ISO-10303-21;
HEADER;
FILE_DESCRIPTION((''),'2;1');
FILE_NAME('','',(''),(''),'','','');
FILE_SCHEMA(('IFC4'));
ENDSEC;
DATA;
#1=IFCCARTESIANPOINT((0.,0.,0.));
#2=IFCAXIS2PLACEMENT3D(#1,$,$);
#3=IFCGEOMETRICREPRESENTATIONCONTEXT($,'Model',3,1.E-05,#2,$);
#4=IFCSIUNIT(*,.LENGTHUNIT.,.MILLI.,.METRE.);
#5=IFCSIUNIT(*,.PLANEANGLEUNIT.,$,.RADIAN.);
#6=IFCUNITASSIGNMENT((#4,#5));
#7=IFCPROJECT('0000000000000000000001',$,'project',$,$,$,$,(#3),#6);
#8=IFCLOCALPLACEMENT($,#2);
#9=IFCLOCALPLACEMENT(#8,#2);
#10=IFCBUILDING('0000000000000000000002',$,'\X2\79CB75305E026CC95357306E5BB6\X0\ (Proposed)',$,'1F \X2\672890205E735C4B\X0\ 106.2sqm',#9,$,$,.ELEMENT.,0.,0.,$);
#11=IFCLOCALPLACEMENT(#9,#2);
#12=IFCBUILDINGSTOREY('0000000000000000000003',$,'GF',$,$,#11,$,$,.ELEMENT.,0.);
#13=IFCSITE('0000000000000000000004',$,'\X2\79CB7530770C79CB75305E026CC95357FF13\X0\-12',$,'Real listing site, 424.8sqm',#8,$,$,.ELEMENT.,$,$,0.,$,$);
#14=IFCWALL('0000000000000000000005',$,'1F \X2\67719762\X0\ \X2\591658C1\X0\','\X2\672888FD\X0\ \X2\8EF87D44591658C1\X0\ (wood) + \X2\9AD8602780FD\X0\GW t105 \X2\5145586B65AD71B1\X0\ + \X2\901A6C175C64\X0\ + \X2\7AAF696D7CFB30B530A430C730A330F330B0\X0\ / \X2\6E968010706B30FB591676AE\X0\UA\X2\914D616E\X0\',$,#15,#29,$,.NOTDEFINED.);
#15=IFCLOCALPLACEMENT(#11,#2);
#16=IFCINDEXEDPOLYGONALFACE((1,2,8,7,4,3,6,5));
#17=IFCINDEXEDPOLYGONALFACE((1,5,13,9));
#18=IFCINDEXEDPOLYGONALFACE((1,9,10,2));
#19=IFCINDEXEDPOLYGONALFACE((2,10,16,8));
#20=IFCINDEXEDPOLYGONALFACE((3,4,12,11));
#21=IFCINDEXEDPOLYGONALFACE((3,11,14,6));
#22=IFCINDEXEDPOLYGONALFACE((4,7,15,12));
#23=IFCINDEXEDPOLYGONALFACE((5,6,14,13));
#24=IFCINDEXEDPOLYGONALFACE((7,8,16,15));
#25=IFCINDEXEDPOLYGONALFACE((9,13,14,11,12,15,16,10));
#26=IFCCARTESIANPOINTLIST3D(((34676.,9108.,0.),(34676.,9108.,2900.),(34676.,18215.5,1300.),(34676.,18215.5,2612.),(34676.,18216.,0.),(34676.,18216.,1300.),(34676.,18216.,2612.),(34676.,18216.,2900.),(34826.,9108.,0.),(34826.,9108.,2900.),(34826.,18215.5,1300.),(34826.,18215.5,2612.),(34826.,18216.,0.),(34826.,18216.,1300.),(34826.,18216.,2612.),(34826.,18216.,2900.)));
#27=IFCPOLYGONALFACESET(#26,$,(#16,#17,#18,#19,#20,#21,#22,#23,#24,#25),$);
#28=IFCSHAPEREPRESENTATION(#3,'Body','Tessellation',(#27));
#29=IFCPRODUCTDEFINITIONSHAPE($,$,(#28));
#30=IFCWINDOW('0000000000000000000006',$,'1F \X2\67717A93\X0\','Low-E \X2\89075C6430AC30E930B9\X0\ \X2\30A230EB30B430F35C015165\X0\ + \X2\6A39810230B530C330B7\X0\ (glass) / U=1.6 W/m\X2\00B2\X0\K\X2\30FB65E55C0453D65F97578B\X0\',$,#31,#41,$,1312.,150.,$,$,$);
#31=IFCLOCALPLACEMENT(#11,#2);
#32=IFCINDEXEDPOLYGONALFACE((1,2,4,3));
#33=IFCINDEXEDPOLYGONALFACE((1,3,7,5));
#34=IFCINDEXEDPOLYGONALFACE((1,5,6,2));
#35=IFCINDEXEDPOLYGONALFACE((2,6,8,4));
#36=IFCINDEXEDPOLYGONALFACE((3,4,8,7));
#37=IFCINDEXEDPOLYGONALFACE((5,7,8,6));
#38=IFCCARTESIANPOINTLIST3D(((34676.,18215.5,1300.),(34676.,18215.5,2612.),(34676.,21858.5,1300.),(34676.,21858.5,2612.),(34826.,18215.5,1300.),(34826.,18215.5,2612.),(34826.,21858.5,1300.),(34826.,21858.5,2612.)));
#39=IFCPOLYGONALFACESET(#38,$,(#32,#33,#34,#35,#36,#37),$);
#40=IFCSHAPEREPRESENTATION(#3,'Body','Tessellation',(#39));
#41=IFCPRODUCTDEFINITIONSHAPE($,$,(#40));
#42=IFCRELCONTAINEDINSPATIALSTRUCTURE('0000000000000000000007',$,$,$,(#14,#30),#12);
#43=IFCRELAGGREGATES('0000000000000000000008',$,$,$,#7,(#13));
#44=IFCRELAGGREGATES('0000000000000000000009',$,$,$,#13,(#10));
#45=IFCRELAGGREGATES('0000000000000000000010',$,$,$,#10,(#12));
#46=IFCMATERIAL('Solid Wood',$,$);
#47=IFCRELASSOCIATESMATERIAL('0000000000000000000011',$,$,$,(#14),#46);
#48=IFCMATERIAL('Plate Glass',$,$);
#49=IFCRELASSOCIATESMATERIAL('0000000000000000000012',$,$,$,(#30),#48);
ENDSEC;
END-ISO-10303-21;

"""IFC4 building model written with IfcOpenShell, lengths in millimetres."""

from ifc_helpers import new_model, si_unit, frame, frame_2d, origin, place, context, project, spatial, rectangle, extrude, material, element, fill, save


model = new_model("IFC4")

# Units and contexts
model_context = context("Model", 3, precision=1e-05, world=origin())
ifc_project = project(units=[si_unit("LENGTHUNIT", "METRE", prefix="MILLI"), si_unit("PLANEANGLEUNIT", "RADIAN")], contexts=[model_context])

# Site, building, storey
site_placement = place(None, origin())
site = spatial("IfcSite", under=ifc_project, at=site_placement, Name="秋田県秋田市泉南３-12", ObjectType="Real listing site, 424.8sqm", CompositionType="ELEMENT", RefElevation=0.0)
building_placement = place(site_placement, origin())
building = spatial("IfcBuilding", under=site, at=building_placement, Name="秋田市泉南の家 (Proposed)", ObjectType="1F 木造平屋 106.2sqm", CompositionType="ELEMENT", ElevationOfRefHeight=0.0, ElevationOfTerrain=0.0)
storey_placement = place(building_placement, origin())
storey = spatial("IfcBuildingStorey", under=building, at=storey_placement, Name="GF", CompositionType="ELEMENT", Elevation=0.0)

# Wall, opening, window
ifc_material_1 = material(Name="Solid Wood")
wall_1_placement = place(storey_placement, frame((17338.0, 4554.0, 0.0)))
wall_1 = element("IfcWall", 1, at=wall_1_placement, inside=storey, material=ifc_material_1, Name="1F 東面 外壁", Description="木製 軸組外壁 (wood) + 高性能GW t105 充填断熱 + 通気層 + 窯業系サイディング / 準耐火・外皮UA配慮", PredefinedType="NOTDEFINED", context=model_context, shape_type="SweptSolid", body=[
    extrude(rectangle(XDim=150.0, YDim=9108.0, at=frame_2d((75.0, 4554.0))), frame((17338.0, 4554.0, 0.0)), (0.0, 0.0, 1.0), 2900.0),
])
opening_1_placement = place(storey_placement, frame((17338.0, 9108.0, 650.0)))
opening_1 = element("IfcOpeningElement", 2, at=opening_1_placement, cuts=wall_1, PredefinedType="NOTDEFINED", context=model_context, shape_type="SweptSolid", body=[
    extrude(rectangle(XDim=150.0, YDim=3643.0, at=frame_2d((75.0, 1821.0))), frame((17338.0, 9108.0, 650.0)), (0.0, 0.0, 1.0), 1312.0),
])
ifc_material_2 = material(Name="Plate Glass")
window_1_placement = place(storey_placement, frame((17338.0, 9108.0, 650.0)))
window_1 = element("IfcWindow", 3, at=window_1_placement, inside=storey, material=ifc_material_2, Name="1F 東窓", Description="Low-E 複層ガラス アルゴン封入 + 樹脂サッシ (glass) / U=1.6 W/m²K・日射取得型", OverallHeight=1312.0, OverallWidth=150.0, context=model_context, shape_type="SweptSolid", body=[
    extrude(rectangle(XDim=150.0, YDim=3643.0, at=frame_2d((75.0, 1821.0))), frame((17338.0, 9108.0, 650.0)), (0.0, 0.0, 1.0), 1312.0),
])
fill(opening_1, window_1)

save(model, "model.ifc")
